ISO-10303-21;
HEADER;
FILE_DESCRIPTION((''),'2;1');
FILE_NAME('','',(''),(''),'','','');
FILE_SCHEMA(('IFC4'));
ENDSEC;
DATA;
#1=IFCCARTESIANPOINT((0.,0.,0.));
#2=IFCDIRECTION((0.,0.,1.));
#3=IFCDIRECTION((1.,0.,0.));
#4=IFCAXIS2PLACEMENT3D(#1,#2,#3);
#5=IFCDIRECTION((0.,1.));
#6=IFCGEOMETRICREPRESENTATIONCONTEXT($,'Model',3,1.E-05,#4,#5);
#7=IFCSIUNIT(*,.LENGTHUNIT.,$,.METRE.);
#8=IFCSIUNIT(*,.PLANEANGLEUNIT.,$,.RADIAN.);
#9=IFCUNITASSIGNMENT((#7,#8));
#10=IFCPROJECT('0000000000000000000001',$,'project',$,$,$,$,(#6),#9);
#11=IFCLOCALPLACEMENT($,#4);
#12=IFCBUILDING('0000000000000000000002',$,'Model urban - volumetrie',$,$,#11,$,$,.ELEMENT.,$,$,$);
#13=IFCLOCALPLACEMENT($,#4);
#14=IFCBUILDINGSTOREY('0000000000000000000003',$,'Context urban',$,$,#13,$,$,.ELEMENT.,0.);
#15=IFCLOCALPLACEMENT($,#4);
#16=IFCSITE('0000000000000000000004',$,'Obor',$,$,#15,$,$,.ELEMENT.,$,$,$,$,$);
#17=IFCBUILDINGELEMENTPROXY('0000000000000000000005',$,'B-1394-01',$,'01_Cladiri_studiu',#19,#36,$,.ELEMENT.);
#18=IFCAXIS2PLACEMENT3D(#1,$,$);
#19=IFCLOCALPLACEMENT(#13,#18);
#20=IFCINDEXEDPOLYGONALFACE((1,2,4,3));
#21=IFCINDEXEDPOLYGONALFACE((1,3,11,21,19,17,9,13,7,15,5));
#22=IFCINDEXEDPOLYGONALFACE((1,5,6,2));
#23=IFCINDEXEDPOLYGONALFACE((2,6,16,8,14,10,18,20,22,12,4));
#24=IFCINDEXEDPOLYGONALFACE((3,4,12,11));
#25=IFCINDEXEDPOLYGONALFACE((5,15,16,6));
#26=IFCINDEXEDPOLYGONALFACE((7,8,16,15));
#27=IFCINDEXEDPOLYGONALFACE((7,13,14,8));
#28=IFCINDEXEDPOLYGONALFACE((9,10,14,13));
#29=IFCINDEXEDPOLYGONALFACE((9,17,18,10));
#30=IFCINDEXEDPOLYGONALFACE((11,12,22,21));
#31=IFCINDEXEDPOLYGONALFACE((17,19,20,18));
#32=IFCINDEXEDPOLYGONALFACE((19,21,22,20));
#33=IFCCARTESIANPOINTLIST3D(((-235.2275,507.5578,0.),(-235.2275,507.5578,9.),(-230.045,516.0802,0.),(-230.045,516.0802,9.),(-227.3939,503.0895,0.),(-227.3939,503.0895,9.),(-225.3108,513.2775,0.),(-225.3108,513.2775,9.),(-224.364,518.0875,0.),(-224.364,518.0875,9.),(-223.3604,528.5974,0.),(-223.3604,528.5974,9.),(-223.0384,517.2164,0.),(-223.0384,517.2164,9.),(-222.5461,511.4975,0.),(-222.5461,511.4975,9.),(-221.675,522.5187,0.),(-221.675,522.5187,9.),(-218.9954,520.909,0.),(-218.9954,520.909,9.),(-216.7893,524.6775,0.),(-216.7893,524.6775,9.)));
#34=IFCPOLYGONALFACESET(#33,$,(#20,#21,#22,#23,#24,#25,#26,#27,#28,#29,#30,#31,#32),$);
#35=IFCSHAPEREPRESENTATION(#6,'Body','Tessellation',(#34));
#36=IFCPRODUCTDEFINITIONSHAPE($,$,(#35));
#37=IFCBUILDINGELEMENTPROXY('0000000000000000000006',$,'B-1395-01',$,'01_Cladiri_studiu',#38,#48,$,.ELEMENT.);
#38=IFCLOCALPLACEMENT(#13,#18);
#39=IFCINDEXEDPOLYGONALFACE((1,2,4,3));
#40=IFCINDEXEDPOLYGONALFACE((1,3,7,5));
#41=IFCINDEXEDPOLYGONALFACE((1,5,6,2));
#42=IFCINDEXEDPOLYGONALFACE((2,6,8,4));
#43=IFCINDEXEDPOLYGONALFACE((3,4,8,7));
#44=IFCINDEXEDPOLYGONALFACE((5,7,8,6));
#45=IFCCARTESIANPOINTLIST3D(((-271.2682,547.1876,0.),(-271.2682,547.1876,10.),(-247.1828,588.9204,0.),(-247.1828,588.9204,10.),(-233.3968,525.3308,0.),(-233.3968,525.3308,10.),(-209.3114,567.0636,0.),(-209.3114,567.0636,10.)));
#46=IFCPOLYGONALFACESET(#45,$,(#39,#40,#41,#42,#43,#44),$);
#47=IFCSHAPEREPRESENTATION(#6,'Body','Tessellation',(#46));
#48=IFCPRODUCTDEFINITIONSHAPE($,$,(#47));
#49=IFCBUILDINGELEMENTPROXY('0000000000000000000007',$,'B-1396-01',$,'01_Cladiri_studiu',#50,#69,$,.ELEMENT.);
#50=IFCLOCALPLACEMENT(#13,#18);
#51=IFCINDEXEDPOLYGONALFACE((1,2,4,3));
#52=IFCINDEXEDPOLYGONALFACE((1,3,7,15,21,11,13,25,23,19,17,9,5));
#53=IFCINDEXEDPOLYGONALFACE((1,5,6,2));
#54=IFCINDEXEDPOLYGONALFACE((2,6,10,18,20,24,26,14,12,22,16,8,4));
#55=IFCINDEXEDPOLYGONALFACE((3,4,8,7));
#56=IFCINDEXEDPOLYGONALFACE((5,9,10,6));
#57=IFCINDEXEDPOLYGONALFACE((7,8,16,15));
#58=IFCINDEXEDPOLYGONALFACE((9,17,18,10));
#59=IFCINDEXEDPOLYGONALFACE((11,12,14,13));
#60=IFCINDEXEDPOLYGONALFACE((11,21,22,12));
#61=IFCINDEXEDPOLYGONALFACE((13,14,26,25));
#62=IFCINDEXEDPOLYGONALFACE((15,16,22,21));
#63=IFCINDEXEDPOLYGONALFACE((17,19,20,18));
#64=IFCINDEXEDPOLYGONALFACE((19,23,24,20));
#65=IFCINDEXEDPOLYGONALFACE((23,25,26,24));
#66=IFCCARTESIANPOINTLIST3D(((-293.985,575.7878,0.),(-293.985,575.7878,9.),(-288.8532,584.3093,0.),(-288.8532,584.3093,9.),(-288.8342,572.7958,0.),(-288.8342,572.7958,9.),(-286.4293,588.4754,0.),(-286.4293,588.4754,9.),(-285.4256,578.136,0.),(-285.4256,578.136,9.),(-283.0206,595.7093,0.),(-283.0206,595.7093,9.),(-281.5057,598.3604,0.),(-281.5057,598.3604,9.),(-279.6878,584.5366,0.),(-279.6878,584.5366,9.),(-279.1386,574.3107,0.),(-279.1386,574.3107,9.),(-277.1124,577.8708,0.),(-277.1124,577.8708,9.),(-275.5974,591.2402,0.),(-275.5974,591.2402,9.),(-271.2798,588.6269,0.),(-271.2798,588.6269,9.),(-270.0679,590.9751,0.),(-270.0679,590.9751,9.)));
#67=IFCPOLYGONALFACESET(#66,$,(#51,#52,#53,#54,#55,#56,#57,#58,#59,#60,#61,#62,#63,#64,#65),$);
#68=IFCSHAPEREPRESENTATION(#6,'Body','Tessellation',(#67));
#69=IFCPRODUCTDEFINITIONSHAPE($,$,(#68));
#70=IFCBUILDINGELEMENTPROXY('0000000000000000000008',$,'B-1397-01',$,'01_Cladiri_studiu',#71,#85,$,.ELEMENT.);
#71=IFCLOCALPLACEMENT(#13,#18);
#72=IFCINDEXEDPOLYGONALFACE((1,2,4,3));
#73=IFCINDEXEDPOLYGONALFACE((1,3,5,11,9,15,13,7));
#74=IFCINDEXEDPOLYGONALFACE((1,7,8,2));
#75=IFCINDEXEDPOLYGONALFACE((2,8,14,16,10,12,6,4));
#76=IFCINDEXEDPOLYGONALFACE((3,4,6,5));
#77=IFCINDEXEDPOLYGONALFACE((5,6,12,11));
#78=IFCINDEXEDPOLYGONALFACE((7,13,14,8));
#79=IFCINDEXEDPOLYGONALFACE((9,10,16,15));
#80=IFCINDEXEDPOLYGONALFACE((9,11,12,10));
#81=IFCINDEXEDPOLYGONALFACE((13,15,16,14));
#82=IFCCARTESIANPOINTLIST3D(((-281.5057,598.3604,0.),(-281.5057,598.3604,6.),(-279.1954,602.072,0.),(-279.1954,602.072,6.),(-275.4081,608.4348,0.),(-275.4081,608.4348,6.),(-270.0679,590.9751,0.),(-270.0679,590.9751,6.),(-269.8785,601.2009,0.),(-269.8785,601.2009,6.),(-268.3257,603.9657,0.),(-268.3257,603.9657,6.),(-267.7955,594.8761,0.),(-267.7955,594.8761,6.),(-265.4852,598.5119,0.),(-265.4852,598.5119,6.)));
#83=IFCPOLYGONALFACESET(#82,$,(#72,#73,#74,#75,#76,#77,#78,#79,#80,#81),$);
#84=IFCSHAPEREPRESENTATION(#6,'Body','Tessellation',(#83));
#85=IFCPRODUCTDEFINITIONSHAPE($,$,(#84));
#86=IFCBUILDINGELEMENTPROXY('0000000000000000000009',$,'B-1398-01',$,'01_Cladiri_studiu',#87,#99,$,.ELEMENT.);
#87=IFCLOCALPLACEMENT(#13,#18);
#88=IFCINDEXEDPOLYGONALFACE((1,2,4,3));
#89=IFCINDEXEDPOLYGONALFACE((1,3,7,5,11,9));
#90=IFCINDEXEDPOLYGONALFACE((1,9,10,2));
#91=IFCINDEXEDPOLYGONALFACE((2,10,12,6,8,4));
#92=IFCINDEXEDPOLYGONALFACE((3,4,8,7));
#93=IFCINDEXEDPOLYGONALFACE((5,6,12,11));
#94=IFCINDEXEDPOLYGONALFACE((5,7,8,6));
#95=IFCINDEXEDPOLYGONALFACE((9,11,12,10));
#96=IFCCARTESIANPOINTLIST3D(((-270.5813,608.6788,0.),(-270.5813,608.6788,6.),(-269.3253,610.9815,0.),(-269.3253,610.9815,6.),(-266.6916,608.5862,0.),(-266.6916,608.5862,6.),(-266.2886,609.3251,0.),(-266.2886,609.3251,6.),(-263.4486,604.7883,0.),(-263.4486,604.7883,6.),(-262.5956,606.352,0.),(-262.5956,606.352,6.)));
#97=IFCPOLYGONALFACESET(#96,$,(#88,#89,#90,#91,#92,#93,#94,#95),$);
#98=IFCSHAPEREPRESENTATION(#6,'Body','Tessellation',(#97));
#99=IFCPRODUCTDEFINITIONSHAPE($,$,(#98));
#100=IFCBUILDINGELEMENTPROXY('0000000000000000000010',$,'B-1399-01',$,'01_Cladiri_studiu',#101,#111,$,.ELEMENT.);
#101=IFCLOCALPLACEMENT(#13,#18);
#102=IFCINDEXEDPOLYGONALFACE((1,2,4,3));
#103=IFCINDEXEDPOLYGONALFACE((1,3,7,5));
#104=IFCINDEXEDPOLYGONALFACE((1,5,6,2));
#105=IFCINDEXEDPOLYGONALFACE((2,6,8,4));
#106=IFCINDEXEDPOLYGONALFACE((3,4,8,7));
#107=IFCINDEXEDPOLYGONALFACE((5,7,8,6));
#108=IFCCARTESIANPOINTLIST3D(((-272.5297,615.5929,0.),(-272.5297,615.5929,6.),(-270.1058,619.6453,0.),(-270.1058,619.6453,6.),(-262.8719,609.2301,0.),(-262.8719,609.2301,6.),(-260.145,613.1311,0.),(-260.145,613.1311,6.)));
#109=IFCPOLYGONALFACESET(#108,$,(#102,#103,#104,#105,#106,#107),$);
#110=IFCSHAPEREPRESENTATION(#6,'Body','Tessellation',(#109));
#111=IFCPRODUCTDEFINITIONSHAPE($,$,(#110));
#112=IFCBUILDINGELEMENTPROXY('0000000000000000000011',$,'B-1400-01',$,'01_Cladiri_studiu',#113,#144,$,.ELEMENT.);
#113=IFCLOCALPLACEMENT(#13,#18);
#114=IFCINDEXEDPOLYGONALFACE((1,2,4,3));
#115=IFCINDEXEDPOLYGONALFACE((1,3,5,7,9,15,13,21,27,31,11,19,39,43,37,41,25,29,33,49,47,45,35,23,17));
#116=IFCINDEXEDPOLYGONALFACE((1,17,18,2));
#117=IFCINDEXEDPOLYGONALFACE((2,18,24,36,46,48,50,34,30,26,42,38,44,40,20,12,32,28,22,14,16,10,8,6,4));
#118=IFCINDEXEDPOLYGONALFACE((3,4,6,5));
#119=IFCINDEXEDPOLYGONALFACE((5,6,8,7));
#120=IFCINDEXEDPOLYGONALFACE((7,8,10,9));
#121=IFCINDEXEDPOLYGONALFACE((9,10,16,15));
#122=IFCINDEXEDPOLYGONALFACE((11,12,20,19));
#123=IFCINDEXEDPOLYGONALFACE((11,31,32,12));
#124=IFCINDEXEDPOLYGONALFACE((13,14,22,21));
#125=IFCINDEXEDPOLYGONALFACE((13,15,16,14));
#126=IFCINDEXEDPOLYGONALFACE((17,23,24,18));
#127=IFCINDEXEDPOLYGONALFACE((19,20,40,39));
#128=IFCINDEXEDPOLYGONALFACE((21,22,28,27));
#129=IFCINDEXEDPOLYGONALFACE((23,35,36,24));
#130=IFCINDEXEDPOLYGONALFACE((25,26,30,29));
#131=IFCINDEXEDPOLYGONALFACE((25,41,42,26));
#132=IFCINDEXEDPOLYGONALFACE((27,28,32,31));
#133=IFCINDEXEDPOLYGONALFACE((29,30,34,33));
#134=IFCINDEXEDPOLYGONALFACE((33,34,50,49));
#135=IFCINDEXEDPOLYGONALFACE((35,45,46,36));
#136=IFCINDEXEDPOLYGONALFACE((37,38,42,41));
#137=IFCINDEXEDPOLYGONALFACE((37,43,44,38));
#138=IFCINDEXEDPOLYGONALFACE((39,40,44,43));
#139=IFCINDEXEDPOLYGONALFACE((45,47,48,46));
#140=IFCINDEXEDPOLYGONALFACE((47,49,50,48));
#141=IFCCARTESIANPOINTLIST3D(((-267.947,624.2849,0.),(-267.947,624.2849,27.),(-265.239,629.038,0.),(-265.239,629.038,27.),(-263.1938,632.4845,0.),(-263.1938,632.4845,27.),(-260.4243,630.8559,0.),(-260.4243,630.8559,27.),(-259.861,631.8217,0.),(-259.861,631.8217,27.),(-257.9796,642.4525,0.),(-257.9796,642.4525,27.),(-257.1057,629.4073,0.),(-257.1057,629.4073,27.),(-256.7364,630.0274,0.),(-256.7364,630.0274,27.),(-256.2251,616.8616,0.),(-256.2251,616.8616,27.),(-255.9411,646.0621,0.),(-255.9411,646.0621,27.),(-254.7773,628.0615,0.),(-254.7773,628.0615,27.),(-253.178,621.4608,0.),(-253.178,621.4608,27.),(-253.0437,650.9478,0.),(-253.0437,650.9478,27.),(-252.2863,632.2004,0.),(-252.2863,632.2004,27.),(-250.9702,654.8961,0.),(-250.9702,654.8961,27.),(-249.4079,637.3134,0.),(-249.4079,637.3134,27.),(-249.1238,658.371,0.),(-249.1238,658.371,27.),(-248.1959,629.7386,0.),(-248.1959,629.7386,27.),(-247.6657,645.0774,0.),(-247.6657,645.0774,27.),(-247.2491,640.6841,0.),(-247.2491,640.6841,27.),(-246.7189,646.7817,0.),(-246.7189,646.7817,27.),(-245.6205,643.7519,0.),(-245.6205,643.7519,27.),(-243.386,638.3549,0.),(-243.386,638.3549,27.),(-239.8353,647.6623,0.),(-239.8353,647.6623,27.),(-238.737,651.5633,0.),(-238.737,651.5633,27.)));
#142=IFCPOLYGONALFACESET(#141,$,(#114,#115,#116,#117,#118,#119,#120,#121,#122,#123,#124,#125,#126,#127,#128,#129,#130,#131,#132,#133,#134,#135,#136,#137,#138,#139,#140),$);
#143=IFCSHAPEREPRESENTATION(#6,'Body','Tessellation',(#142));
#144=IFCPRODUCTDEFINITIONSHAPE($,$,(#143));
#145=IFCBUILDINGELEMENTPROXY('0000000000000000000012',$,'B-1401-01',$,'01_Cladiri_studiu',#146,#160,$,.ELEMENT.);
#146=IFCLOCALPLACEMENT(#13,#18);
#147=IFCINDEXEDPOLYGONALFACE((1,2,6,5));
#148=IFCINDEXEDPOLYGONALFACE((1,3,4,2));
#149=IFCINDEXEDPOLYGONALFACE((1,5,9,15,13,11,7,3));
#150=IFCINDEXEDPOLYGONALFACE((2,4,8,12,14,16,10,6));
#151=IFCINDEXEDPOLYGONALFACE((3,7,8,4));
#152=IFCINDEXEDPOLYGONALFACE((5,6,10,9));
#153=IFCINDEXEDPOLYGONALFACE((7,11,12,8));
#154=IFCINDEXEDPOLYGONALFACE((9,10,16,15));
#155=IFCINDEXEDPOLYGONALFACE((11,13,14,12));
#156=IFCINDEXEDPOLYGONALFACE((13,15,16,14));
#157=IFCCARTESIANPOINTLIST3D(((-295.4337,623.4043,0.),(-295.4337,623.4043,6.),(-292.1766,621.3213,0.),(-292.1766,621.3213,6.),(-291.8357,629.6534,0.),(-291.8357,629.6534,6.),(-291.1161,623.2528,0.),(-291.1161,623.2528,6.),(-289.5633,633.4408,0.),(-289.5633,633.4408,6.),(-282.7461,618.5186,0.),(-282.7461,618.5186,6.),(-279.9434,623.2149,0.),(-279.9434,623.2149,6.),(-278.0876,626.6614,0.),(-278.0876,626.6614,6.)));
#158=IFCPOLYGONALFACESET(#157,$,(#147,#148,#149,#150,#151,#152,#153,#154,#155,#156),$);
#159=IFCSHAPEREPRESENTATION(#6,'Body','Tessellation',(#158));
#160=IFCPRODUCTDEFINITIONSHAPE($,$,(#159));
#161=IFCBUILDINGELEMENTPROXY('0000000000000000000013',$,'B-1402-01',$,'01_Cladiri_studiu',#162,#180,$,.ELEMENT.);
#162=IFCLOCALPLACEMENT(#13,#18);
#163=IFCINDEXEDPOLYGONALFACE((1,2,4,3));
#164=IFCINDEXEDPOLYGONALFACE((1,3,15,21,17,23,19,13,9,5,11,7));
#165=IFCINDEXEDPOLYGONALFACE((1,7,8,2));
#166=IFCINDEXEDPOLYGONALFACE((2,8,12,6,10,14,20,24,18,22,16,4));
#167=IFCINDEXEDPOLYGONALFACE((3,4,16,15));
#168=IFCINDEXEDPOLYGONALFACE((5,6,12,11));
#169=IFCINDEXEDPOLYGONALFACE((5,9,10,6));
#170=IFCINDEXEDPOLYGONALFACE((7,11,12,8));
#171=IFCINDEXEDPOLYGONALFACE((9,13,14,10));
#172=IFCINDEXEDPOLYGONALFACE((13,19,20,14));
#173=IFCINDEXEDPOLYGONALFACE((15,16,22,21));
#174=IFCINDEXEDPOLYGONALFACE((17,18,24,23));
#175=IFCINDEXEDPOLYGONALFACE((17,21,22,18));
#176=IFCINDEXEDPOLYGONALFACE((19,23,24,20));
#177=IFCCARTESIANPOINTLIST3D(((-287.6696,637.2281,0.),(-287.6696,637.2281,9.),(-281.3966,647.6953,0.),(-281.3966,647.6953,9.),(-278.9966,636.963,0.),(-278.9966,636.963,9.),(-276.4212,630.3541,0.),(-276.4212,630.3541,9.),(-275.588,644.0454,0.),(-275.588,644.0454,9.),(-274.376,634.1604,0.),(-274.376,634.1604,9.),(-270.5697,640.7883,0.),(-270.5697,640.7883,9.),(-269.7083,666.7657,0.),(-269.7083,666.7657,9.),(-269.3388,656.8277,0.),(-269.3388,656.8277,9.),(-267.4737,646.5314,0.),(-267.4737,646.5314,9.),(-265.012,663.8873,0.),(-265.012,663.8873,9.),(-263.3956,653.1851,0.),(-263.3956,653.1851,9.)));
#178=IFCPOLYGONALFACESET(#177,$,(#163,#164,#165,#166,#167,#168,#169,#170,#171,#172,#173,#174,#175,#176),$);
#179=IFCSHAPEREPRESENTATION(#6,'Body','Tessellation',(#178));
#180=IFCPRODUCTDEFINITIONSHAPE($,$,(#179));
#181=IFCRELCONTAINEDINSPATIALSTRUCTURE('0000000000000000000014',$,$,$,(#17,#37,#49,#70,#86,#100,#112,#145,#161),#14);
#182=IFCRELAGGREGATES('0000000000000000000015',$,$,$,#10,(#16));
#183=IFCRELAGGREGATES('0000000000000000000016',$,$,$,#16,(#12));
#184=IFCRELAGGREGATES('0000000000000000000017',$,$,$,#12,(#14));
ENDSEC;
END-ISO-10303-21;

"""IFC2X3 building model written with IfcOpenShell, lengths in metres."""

from ifc_helpers import new_model, si_unit, direction, origin_with_axes, place, context, project, spatial, polyline, outline, extrude, element, save


model = new_model("IFC2X3")

# Units and contexts
model_context = context("Model", 3, precision=1e-05, world=origin_with_axes(), true_north=direction((0.0, 1.0)))
ifc_project = project(units=[si_unit("LENGTHUNIT", "METRE"), si_unit("PLANEANGLEUNIT", "RADIAN")], contexts=[model_context])

# Site, building, storey
site_placement = place(None, origin_with_axes())
site = spatial("IfcSite", under=ifc_project, at=site_placement, Name="Obor", CompositionType="ELEMENT")
building_placement = place(None, origin_with_axes())
building = spatial("IfcBuilding", under=site, at=building_placement, Name="Model urban - volumetrie", CompositionType="ELEMENT")
storey_placement = place(None, origin_with_axes())
storey = spatial("IfcBuildingStorey", under=building, at=storey_placement, Name="Context urban", CompositionType="ELEMENT", Elevation=0.0)

# Building element proxies
proxy_1_placement = place(None, origin_with_axes())
element("IfcBuildingElementProxy", 1, at=proxy_1_placement, inside=storey, Name="B-1394-01", ObjectType="01_Cladiri_studiu", CompositionType="ELEMENT", context=model_context, shape_type="SweptSolid", body=[
    extrude(outline(polyline([(-227.3939, 503.0895), (-222.5461, 511.4975), (-225.3108, 513.2775), (-223.0384, 517.2164), (-224.364, 518.0875), (-221.675, 522.5187), (-218.9954, 520.909), (-216.7893, 524.6775), (-223.3604, 528.5974), (-230.045, 516.0802), (-235.2275, 507.5578), (-227.3939, 503.0895)])), origin_with_axes(), (0.0, 0.0, 1.0), 9.0),
])
proxy_2_placement = place(None, origin_with_axes())
element("IfcBuildingElementProxy", 2, at=proxy_2_placement, inside=storey, Name="B-1395-01", ObjectType="01_Cladiri_studiu", CompositionType="ELEMENT", context=model_context, shape_type="SweptSolid", body=[
    extrude(outline(polyline([(-209.3114, 567.0636), (-247.1828, 588.9204), (-271.2682, 547.1876), (-233.3968, 525.3308), (-209.3114, 567.0636)])), origin_with_axes(), (0.0, 0.0, 1.0), 10.0),
])
proxy_3_placement = place(None, origin_with_axes())
element("IfcBuildingElementProxy", 3, at=proxy_3_placement, inside=storey, Name="B-1396-01", ObjectType="01_Cladiri_studiu", CompositionType="ELEMENT", context=model_context, shape_type="SweptSolid", body=[
    extrude(outline(polyline([(-285.4256, 578.136), (-279.1386, 574.3107), (-277.1124, 577.8708), (-271.2798, 588.6269), (-270.0679, 590.9751), (-281.5057, 598.3604), (-283.0206, 595.7093), (-275.5974, 591.2402), (-279.6878, 584.5366), (-286.4293, 588.4754), (-288.8532, 584.3093), (-293.985, 575.7878), (-288.8342, 572.7958), (-285.4256, 578.136)])), origin_with_axes(), (0.0, 0.0, 1.0), 9.0),
])
proxy_4_placement = place(None, origin_with_axes())
element("IfcBuildingElementProxy", 4, at=proxy_4_placement, inside=storey, Name="B-1397-01", ObjectType="01_Cladiri_studiu", CompositionType="ELEMENT", context=model_context, shape_type="SweptSolid", body=[
    extrude(outline(polyline([(-268.3257, 603.9657), (-275.4081, 608.4348), (-279.1954, 602.072), (-281.5057, 598.3604), (-270.0679, 590.9751), (-267.7955, 594.8761), (-265.4852, 598.5119), (-269.8785, 601.2009), (-268.3257, 603.9657)])), origin_with_axes(), (0.0, 0.0, 1.0), 6.0),
])
proxy_5_placement = place(None, origin_with_axes())
element("IfcBuildingElementProxy", 5, at=proxy_5_placement, inside=storey, Name="B-1398-01", ObjectType="01_Cladiri_studiu", CompositionType="ELEMENT", context=model_context, shape_type="SweptSolid", body=[
    extrude(outline(polyline([(-266.6916, 608.5862), (-266.2886, 609.3251), (-269.3253, 610.9815), (-270.5813, 608.6788), (-263.4486, 604.7883), (-262.5956, 606.352), (-266.6916, 608.5862)])), origin_with_axes(), (0.0, 0.0, 1.0), 6.0),
])
proxy_6_placement = place(None, origin_with_axes())
element("IfcBuildingElementProxy", 6, at=proxy_6_placement, inside=storey, Name="B-1399-01", ObjectType="01_Cladiri_studiu", CompositionType="ELEMENT", context=model_context, shape_type="SweptSolid", body=[
    extrude(outline(polyline([(-272.5297, 615.5929), (-262.8719, 609.2301), (-260.145, 613.1311), (-270.1058, 619.6453), (-272.5297, 615.5929)])), origin_with_axes(), (0.0, 0.0, 1.0), 6.0),
])
proxy_7_placement = place(None, origin_with_axes())
element("IfcBuildingElementProxy", 7, at=proxy_7_placement, inside=storey, Name="B-1400-01", ObjectType="01_Cladiri_studiu", CompositionType="ELEMENT", context=model_context, shape_type="SweptSolid", body=[
    extrude(outline(polyline([(-255.9411, 646.0621), (-257.9796, 642.4525), (-249.4079, 637.3134), (-252.2863, 632.2004), (-254.7773, 628.0615), (-257.1057, 629.4073), (-256.7364, 630.0274), (-259.861, 631.8217), (-260.4243, 630.8559), (-263.1938, 632.4845), (-265.239, 629.038), (-267.947, 624.2849), (-256.2251, 616.8616), (-253.178, 621.4608), (-248.1959, 629.7386), (-243.386, 638.3549), (-239.8353, 647.6623), (-238.737, 651.5633), (-249.1238, 658.371), (-250.9702, 654.8961), (-253.0437, 650.9478), (-246.7189, 646.7817), (-247.6657, 645.0774), (-245.6205, 643.7519), (-247.2491, 640.6841), (-255.9411, 646.0621)])), origin_with_axes(), (0.0, 0.0, 1.0), 27.0),
])
proxy_8_placement = place(None, origin_with_axes())
element("IfcBuildingElementProxy", 8, at=proxy_8_placement, inside=storey, Name="B-1401-01", ObjectType="01_Cladiri_studiu", CompositionType="ELEMENT", context=model_context, shape_type="SweptSolid", body=[
    extrude(outline(polyline([(-291.8357, 629.6534), (-295.4337, 623.4043), (-292.1766, 621.3213), (-291.1161, 623.2528), (-282.7461, 618.5186), (-279.9434, 623.2149), (-278.0876, 626.6614), (-289.5633, 633.4408), (-291.8357, 629.6534)])), origin_with_axes(), (0.0, 0.0, 1.0), 6.0),
])
proxy_9_placement = place(None, origin_with_axes())
element("IfcBuildingElementProxy", 9, at=proxy_9_placement, inside=storey, Name="B-1402-01", ObjectType="01_Cladiri_studiu", CompositionType="ELEMENT", context=model_context, shape_type="SweptSolid", body=[
    extrude(outline(polyline([(-275.588, 644.0454), (-270.5697, 640.7883), (-267.4737, 646.5314), (-263.3956, 653.1851), (-269.3388, 656.8277), (-265.012, 663.8873), (-269.7083, 666.7657), (-281.3966, 647.6953), (-287.6696, 637.2281), (-276.4212, 630.3541), (-274.376, 634.1604), (-278.9966, 636.963), (-275.588, 644.0454)])), origin_with_axes(), (0.0, 0.0, 1.0), 9.0),
])

save(model, "model.ifc")
